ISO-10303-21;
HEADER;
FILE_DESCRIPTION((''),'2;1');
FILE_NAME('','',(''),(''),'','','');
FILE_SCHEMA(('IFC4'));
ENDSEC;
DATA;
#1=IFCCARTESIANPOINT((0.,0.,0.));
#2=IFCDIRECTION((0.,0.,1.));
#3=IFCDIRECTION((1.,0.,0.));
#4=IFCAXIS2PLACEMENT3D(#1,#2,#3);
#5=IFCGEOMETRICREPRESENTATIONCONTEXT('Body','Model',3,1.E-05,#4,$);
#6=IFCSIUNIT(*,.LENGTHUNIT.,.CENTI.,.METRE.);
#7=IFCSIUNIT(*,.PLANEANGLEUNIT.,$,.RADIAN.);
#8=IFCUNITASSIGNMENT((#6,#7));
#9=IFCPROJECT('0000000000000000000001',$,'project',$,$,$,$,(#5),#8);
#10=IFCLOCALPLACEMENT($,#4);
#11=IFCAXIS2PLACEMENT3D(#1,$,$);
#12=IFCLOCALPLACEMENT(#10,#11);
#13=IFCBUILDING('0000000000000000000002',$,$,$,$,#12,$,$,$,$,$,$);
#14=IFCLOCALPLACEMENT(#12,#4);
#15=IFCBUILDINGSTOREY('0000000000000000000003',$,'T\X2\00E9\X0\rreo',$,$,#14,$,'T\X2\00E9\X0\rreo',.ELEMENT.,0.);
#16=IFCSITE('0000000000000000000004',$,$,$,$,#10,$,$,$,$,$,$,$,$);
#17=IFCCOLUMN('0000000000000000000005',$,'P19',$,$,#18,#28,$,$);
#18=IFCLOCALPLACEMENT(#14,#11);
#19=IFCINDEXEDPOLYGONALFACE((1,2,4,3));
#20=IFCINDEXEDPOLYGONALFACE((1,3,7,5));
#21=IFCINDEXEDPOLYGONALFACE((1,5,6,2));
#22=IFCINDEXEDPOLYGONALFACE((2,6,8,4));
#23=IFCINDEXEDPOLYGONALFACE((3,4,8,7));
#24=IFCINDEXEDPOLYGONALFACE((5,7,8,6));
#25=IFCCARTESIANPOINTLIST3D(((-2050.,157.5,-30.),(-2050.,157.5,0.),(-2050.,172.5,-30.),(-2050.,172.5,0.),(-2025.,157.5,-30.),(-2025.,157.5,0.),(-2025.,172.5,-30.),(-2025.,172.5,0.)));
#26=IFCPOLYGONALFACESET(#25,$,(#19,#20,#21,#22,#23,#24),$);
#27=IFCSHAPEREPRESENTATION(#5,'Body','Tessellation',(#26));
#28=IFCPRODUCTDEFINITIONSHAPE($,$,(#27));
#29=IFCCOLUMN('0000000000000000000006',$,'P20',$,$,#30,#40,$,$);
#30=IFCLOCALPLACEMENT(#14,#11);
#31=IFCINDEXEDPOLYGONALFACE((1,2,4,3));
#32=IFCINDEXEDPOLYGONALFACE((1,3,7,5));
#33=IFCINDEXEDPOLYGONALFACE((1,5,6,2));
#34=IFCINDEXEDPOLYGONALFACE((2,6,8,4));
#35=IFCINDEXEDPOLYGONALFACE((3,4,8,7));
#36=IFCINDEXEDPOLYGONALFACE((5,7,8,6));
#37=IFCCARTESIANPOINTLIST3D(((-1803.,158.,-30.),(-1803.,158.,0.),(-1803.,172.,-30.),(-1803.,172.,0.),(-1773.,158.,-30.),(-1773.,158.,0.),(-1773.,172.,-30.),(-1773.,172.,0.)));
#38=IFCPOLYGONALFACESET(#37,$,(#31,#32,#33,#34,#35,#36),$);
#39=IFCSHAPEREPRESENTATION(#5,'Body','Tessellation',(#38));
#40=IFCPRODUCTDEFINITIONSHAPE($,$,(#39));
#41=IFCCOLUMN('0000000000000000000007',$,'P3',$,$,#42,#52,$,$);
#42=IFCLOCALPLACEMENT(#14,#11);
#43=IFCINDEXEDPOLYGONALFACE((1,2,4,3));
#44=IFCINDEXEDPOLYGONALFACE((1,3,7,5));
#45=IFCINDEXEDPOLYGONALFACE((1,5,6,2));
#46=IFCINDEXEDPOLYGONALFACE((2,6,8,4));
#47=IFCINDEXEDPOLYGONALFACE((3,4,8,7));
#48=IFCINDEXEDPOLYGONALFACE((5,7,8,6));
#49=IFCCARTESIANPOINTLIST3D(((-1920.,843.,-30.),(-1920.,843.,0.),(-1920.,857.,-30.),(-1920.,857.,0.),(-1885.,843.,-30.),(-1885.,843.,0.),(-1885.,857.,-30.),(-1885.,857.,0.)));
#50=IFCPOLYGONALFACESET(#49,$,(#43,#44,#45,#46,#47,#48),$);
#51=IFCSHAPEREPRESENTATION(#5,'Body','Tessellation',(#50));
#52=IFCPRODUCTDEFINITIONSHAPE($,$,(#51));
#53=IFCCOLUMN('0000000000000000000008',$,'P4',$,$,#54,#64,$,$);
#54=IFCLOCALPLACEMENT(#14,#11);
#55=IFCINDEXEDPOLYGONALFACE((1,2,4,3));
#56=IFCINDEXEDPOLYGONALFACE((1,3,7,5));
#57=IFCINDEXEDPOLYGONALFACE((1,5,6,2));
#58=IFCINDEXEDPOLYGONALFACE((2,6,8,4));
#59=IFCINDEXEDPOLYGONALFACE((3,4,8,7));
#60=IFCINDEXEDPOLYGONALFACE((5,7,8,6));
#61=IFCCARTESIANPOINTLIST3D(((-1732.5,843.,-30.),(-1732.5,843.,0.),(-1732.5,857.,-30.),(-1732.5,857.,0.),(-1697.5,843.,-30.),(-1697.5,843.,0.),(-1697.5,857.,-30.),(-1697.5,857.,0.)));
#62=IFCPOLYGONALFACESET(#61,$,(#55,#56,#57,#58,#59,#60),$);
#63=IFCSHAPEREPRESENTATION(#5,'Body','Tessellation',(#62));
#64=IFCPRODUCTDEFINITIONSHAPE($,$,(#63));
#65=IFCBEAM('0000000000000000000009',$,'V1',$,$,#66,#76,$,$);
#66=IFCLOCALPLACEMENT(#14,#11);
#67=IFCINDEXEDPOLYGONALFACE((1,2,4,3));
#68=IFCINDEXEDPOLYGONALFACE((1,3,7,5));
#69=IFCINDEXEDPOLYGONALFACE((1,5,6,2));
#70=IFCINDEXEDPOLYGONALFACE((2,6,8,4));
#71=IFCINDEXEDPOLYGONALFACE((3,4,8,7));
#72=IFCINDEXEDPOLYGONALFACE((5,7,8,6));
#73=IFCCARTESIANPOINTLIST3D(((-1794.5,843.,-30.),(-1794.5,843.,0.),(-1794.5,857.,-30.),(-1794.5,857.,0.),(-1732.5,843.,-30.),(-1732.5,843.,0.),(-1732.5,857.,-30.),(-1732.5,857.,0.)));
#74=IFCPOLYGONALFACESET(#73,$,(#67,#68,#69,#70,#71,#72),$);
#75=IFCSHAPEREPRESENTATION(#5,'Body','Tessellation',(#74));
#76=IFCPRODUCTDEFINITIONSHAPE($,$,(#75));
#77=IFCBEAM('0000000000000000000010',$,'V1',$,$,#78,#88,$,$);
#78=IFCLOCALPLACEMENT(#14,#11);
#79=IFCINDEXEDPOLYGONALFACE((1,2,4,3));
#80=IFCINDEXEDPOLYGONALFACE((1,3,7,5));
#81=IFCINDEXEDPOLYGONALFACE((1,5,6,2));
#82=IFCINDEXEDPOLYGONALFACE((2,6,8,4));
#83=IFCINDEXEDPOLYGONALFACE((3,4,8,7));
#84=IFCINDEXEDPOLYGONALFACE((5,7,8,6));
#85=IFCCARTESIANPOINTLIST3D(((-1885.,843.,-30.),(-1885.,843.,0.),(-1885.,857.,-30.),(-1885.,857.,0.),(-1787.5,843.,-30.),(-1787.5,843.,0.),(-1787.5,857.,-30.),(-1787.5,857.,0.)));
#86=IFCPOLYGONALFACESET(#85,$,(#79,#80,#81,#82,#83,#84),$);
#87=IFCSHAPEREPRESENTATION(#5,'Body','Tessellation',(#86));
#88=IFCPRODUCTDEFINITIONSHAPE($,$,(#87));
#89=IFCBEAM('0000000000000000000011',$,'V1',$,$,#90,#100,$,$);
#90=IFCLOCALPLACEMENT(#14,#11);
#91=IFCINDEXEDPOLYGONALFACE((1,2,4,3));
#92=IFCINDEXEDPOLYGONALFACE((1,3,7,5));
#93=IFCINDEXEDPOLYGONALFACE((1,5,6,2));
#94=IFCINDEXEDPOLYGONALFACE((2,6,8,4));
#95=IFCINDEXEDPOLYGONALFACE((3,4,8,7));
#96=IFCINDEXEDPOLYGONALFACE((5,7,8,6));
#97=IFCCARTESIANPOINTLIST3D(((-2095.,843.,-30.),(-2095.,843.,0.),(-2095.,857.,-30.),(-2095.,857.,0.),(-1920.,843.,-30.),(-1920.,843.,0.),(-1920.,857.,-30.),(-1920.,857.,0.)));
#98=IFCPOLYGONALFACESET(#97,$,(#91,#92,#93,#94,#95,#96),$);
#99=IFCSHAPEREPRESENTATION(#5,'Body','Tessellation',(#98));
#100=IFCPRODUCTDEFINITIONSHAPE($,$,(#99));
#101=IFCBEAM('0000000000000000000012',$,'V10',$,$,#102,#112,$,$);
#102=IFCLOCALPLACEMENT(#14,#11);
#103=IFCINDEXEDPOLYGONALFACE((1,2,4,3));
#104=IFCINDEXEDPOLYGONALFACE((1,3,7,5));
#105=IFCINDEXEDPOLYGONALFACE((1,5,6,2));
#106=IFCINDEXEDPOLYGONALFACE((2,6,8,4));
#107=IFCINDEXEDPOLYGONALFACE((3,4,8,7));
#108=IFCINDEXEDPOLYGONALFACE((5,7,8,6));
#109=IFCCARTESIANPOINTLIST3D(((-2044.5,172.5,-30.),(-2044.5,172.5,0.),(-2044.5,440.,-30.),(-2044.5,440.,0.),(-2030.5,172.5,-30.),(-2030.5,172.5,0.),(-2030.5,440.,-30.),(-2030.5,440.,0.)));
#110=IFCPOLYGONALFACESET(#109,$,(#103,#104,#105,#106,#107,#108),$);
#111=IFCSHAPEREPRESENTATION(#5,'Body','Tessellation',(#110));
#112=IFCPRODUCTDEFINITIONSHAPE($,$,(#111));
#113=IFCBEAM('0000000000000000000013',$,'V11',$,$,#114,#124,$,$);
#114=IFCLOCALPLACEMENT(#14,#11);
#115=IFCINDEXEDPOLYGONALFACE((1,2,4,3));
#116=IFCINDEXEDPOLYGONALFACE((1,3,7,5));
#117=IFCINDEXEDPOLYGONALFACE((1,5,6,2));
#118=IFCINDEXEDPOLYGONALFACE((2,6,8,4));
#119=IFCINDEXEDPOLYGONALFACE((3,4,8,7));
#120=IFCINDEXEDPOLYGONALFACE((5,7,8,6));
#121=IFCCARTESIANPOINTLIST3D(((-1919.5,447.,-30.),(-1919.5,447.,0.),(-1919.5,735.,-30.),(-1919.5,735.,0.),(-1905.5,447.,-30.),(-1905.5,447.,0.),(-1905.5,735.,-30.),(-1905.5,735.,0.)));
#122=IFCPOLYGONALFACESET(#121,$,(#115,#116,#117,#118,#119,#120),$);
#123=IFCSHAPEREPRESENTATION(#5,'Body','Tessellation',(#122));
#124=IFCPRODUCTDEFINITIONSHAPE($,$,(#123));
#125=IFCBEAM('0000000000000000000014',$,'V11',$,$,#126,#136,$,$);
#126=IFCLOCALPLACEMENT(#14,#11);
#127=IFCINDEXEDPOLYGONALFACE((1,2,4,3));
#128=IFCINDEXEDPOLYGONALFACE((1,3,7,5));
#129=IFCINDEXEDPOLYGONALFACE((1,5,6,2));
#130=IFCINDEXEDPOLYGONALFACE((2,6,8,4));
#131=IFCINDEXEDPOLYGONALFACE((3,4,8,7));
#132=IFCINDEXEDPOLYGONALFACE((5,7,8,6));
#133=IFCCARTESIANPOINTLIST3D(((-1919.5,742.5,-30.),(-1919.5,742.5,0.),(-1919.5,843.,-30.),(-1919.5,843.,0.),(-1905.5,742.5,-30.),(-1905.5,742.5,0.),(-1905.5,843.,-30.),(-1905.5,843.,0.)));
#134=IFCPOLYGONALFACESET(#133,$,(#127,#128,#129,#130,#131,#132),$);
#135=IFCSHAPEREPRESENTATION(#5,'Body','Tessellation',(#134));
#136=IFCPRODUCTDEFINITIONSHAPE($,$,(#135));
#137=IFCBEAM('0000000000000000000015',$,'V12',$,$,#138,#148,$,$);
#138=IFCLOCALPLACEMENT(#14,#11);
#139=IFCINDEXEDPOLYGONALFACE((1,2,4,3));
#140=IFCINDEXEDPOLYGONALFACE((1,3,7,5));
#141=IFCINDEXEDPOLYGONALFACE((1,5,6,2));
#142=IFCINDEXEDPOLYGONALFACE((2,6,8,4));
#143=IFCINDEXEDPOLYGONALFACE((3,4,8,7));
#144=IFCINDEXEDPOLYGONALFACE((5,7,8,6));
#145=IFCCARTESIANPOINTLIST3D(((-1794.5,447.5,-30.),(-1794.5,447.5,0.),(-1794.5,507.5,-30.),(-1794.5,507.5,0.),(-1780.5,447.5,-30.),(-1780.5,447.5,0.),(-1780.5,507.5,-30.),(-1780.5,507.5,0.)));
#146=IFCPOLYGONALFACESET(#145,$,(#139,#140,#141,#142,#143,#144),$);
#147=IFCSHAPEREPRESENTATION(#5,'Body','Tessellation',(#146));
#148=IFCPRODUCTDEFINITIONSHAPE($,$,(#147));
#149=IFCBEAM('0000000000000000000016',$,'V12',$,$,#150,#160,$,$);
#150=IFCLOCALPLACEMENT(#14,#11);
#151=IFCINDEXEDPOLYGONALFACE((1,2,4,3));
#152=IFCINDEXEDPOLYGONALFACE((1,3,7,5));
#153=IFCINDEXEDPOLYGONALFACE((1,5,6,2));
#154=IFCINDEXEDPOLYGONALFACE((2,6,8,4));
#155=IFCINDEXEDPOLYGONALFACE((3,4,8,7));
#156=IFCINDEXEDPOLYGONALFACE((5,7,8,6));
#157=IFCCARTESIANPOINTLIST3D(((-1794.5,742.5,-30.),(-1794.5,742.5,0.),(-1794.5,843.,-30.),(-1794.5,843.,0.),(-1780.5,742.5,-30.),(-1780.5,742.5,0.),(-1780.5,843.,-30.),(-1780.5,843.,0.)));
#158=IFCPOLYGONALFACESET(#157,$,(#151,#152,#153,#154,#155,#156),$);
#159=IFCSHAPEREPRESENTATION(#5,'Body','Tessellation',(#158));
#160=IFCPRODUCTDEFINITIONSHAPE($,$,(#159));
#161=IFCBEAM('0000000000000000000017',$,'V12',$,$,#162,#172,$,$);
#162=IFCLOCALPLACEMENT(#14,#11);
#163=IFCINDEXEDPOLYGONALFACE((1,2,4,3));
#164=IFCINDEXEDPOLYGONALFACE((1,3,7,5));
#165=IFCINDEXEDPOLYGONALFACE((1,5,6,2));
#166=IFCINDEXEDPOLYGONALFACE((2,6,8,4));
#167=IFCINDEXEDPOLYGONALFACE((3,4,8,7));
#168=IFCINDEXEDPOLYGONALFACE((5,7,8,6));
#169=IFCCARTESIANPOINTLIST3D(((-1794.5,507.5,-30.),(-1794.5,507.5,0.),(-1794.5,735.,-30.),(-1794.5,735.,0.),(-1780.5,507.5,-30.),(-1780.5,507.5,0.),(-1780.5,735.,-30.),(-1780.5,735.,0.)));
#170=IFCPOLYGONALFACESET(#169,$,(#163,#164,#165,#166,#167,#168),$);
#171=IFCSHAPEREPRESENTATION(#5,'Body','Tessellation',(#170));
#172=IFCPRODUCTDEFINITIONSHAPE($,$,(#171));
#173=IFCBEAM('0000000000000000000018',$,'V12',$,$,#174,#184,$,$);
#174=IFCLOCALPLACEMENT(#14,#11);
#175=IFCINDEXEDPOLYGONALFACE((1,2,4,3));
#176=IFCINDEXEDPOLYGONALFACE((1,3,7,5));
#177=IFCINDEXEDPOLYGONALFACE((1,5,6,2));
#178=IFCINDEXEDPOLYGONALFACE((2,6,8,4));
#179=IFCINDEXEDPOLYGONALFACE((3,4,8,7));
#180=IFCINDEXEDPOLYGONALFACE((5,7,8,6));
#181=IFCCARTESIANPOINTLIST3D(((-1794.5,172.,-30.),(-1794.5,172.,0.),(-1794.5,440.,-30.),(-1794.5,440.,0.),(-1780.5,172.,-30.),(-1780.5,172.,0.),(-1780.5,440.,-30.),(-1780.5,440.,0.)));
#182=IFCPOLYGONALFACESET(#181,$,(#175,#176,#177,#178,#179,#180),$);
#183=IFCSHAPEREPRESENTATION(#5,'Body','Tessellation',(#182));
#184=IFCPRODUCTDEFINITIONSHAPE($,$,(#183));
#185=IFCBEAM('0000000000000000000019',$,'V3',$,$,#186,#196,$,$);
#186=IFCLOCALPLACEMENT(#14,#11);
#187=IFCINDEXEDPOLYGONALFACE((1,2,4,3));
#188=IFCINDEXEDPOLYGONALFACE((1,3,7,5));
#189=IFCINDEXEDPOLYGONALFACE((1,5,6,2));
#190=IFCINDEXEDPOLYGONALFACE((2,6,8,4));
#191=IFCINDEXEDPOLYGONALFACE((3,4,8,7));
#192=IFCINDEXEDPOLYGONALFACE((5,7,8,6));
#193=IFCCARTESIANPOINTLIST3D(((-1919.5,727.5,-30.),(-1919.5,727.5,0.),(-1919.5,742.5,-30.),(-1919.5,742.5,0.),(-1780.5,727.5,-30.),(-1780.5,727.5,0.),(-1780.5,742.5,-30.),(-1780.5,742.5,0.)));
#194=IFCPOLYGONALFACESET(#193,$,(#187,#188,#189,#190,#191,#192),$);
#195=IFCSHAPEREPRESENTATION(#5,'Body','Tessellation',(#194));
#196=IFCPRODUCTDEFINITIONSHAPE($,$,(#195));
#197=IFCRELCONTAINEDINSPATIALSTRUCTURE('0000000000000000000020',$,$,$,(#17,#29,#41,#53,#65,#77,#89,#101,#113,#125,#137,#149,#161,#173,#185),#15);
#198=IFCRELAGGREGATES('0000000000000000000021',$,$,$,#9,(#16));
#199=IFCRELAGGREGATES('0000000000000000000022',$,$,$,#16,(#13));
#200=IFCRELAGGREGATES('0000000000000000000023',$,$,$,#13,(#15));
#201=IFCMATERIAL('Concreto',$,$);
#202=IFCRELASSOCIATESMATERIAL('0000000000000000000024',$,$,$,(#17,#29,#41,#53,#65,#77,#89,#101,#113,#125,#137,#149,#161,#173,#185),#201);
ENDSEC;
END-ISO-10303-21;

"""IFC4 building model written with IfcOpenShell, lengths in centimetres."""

from ifc_helpers import new_model, si_unit, frame, origin, origin_with_axes, origin_2d_with_axis, place, context, project, spatial, rectangle, extrude, material, element, save


model = new_model("IFC4")

# Units and contexts
model_context = context("Model", 3, precision=1e-05, world=origin_with_axes(), identifier="Body")
ifc_project = project(units=[si_unit("LENGTHUNIT", "METRE", prefix="CENTI"), si_unit("PLANEANGLEUNIT", "RADIAN")], contexts=[model_context])

# Site, building, storey
site_placement = place(None, origin_with_axes())
site = spatial("IfcSite", under=ifc_project, at=site_placement)
building_placement = place(site_placement, origin())
building = spatial("IfcBuilding", under=site, at=building_placement)
storey_placement = place(building_placement, origin_with_axes())
storey = spatial("IfcBuildingStorey", under=building, at=storey_placement, Name="Térreo", LongName="Térreo", CompositionType="ELEMENT", Elevation=0.0)

# Shared definitions
ifc_material = material(Name="Concreto")

# Columns
column_1_placement = place(storey_placement, frame((-2037.5, 165.0, 0.0), z_axis=(0.0, 0.0, 1.0), x_axis=(1.0, 0.0, 0.0)))
element("IfcColumn", 1, at=column_1_placement, inside=storey, material=ifc_material, Name="P19", context=model_context, shape_type="SolidModel", body=[
    extrude(rectangle(XDim=15.0, YDim=25.0, at=origin_2d_with_axis()), frame((0.0, 0.0, -30.0), z_axis=(0.0, 0.0, 1.0), x_axis=(0.0, 1.0, 0.0)), (0.0, 0.0, 1.0), 30.0),
])
column_2_placement = place(storey_placement, frame((-1788.0, 165.0, 0.0), z_axis=(0.0, 0.0, 1.0), x_axis=(1.0, 0.0, 0.0)))
element("IfcColumn", 2, at=column_2_placement, inside=storey, material=ifc_material, Name="P20", context=model_context, shape_type="SolidModel", body=[
    extrude(rectangle(XDim=14.0, YDim=30.0, at=origin_2d_with_axis()), frame((0.0, 0.0, -30.0), z_axis=(0.0, 0.0, 1.0), x_axis=(0.0, -1.0, 0.0)), (0.0, 0.0, 1.0), 30.0),
])
for number, where, z_axis, x_axis, name in (
    (3, (-1902.5, 850.0, 0.0), (0.0, 0.0, 1.0), (1.0, 0.0, 0.0), "P3"),
    (4, (-1715.0, 850.0, 0.0), (0.0, 0.0, 1.0), (1.0, 0.0, 0.0), "P4"),
):
    element("IfcColumn", number, at=place(storey_placement, frame(where, z_axis=z_axis, x_axis=x_axis)), inside=storey, material=ifc_material, Name=name, context=model_context, shape_type="SolidModel", body=[
        extrude(rectangle(XDim=14.0, YDim=35.0, at=origin_2d_with_axis()), frame((0.0, 0.0, -30.0), z_axis=(0.0, 0.0, 1.0), x_axis=(0.0, 1.0, 0.0)), (0.0, 0.0, 1.0), 30.0),
    ])

# Beams
beam_1_placement = place(storey_placement, frame((-1763.5, 850.0, 0.0), z_axis=(0.0, 0.0, 1.0), x_axis=(1.0, 0.0, 0.0)))
element("IfcBeam", 5, at=beam_1_placement, inside=storey, material=ifc_material, Name="V1", context=model_context, shape_type="SolidModel", body=[
    extrude(rectangle(XDim=14.0, YDim=30.0, at=origin_2d_with_axis()), frame((-31.0, 0.0, -15.0), z_axis=(1.0, 0.0, 0.0), x_axis=(0.0, -1.0, 0.0)), (0.0, 0.0, 1.0), 62.0),
])
beam_2_placement = place(storey_placement, frame((-1836.25, 850.0, 0.0), z_axis=(0.0, 0.0, 1.0), x_axis=(1.0, 0.0, 0.0)))
element("IfcBeam", 6, at=beam_2_placement, inside=storey, material=ifc_material, Name="V1", context=model_context, shape_type="SolidModel", body=[
    extrude(rectangle(XDim=14.0, YDim=30.0, at=origin_2d_with_axis()), frame((-48.75, 0.0, -15.0), z_axis=(1.0, 0.0, 0.0), x_axis=(0.0, -1.0, 0.0)), (0.0, 0.0, 1.0), 97.5),
])
beam_3_placement = place(storey_placement, frame((-2007.5, 850.0, 0.0), z_axis=(0.0, 0.0, 1.0), x_axis=(1.0, 0.0, 0.0)))
element("IfcBeam", 7, at=beam_3_placement, inside=storey, material=ifc_material, Name="V1", context=model_context, shape_type="SolidModel", body=[
    extrude(rectangle(XDim=14.0, YDim=30.0, at=origin_2d_with_axis()), frame((-87.5, 0.0, -15.0), z_axis=(1.0, 0.0, 0.0), x_axis=(0.0, -1.0, 0.0)), (0.0, 0.0, 1.0), 175.0),
])
beam_4_placement = place(storey_placement, frame((-2037.5, 306.25, 0.0), z_axis=(0.0, 0.0, 1.0), x_axis=(1.0, 0.0, 0.0)))
element("IfcBeam", 8, at=beam_4_placement, inside=storey, material=ifc_material, Name="V10", context=model_context, shape_type="SolidModel", body=[
    extrude(rectangle(XDim=14.0, YDim=30.0, at=origin_2d_with_axis()), frame((0.0, -133.75, -15.0), z_axis=(0.0, 1.0, 0.0), x_axis=(-1.0, 0.0, 0.0)), (0.0, 0.0, 1.0), 267.5),
])
beam_5_placement = place(storey_placement, frame((-1912.5, 591.0, 0.0), z_axis=(0.0, 0.0, 1.0), x_axis=(1.0, 0.0, 0.0)))
element("IfcBeam", 9, at=beam_5_placement, inside=storey, material=ifc_material, Name="V11", context=model_context, shape_type="SolidModel", body=[
    extrude(rectangle(XDim=14.0, YDim=30.0, at=origin_2d_with_axis()), frame((0.0, -144.0, -15.0), z_axis=(0.0, 1.0, 0.0), x_axis=(-1.0, 0.0, 0.0)), (0.0, 0.0, 1.0), 288.0),
])
beam_6_placement = place(storey_placement, frame((-1912.5, 792.75, 0.0), z_axis=(0.0, 0.0, 1.0), x_axis=(1.0, 0.0, 0.0)))
element("IfcBeam", 10, at=beam_6_placement, inside=storey, material=ifc_material, Name="V11", context=model_context, shape_type="SolidModel", body=[
    extrude(rectangle(XDim=14.0, YDim=30.0, at=origin_2d_with_axis()), frame((0.0, -50.25, -15.0), z_axis=(0.0, 1.0, 0.0), x_axis=(-1.0, 0.0, 0.0)), (0.0, 0.0, 1.0), 100.5),
])
beam_7_placement = place(storey_placement, frame((-1787.5, 477.5, 0.0), z_axis=(0.0, 0.0, 1.0), x_axis=(1.0, 0.0, 0.0)))
element("IfcBeam", 11, at=beam_7_placement, inside=storey, material=ifc_material, Name="V12", context=model_context, shape_type="SolidModel", body=[
    extrude(rectangle(XDim=14.0, YDim=30.0, at=origin_2d_with_axis()), frame((0.0, -30.0, -15.0), z_axis=(0.0, 1.0, 0.0), x_axis=(-1.0, 0.0, 0.0)), (0.0, 0.0, 1.0), 60.0),
])
beam_8_placement = place(storey_placement, frame((-1787.5, 792.75, 0.0), z_axis=(0.0, 0.0, 1.0), x_axis=(1.0, 0.0, 0.0)))
element("IfcBeam", 12, at=beam_8_placement, inside=storey, material=ifc_material, Name="V12", context=model_context, shape_type="SolidModel", body=[
    extrude(rectangle(XDim=14.0, YDim=30.0, at=origin_2d_with_axis()), frame((0.0, -50.25, -15.0), z_axis=(0.0, 1.0, 0.0), x_axis=(-1.0, 0.0, 0.0)), (0.0, 0.0, 1.0), 100.5),
])
beam_9_placement = place(storey_placement, frame((-1787.5, 621.25, 0.0), z_axis=(0.0, 0.0, 1.0), x_axis=(1.0, 0.0, 0.0)))
element("IfcBeam", 13, at=beam_9_placement, inside=storey, material=ifc_material, Name="V12", context=model_context, shape_type="SolidModel", body=[
    extrude(rectangle(XDim=14.0, YDim=30.0, at=origin_2d_with_axis()), frame((0.0, -113.75, -15.0), z_axis=(0.0, 1.0, 0.0), x_axis=(-1.0, 0.0, 0.0)), (0.0, 0.0, 1.0), 227.5),
])
beam_10_placement = place(storey_placement, frame((-1787.5, 306.0, 0.0), z_axis=(0.0, 0.0, 1.0), x_axis=(1.0, 0.0, 0.0)))
element("IfcBeam", 14, at=beam_10_placement, inside=storey, material=ifc_material, Name="V12", context=model_context, shape_type="SolidModel", body=[
    extrude(rectangle(XDim=14.0, YDim=30.0, at=origin_2d_with_axis()), frame((0.0, -134.0, -15.0), z_axis=(0.0, 1.0, 0.0), x_axis=(-1.0, 0.0, 0.0)), (0.0, 0.0, 1.0), 268.0),
])
beam_11_placement = place(storey_placement, frame((-1850.0, 735.0, 0.0), z_axis=(0.0, 0.0, 1.0), x_axis=(1.0, 0.0, 0.0)))
element("IfcBeam", 15, at=beam_11_placement, inside=storey, material=ifc_material, Name="V3", context=model_context, shape_type="SolidModel", body=[
    extrude(rectangle(XDim=15.0, YDim=30.0, at=origin_2d_with_axis()), frame((-69.5, 0.0, -15.0), z_axis=(1.0, 0.0, 0.0), x_axis=(0.0, -1.0, 0.0)), (0.0, 0.0, 1.0), 139.0),
])

save(model, "model.ifc")
